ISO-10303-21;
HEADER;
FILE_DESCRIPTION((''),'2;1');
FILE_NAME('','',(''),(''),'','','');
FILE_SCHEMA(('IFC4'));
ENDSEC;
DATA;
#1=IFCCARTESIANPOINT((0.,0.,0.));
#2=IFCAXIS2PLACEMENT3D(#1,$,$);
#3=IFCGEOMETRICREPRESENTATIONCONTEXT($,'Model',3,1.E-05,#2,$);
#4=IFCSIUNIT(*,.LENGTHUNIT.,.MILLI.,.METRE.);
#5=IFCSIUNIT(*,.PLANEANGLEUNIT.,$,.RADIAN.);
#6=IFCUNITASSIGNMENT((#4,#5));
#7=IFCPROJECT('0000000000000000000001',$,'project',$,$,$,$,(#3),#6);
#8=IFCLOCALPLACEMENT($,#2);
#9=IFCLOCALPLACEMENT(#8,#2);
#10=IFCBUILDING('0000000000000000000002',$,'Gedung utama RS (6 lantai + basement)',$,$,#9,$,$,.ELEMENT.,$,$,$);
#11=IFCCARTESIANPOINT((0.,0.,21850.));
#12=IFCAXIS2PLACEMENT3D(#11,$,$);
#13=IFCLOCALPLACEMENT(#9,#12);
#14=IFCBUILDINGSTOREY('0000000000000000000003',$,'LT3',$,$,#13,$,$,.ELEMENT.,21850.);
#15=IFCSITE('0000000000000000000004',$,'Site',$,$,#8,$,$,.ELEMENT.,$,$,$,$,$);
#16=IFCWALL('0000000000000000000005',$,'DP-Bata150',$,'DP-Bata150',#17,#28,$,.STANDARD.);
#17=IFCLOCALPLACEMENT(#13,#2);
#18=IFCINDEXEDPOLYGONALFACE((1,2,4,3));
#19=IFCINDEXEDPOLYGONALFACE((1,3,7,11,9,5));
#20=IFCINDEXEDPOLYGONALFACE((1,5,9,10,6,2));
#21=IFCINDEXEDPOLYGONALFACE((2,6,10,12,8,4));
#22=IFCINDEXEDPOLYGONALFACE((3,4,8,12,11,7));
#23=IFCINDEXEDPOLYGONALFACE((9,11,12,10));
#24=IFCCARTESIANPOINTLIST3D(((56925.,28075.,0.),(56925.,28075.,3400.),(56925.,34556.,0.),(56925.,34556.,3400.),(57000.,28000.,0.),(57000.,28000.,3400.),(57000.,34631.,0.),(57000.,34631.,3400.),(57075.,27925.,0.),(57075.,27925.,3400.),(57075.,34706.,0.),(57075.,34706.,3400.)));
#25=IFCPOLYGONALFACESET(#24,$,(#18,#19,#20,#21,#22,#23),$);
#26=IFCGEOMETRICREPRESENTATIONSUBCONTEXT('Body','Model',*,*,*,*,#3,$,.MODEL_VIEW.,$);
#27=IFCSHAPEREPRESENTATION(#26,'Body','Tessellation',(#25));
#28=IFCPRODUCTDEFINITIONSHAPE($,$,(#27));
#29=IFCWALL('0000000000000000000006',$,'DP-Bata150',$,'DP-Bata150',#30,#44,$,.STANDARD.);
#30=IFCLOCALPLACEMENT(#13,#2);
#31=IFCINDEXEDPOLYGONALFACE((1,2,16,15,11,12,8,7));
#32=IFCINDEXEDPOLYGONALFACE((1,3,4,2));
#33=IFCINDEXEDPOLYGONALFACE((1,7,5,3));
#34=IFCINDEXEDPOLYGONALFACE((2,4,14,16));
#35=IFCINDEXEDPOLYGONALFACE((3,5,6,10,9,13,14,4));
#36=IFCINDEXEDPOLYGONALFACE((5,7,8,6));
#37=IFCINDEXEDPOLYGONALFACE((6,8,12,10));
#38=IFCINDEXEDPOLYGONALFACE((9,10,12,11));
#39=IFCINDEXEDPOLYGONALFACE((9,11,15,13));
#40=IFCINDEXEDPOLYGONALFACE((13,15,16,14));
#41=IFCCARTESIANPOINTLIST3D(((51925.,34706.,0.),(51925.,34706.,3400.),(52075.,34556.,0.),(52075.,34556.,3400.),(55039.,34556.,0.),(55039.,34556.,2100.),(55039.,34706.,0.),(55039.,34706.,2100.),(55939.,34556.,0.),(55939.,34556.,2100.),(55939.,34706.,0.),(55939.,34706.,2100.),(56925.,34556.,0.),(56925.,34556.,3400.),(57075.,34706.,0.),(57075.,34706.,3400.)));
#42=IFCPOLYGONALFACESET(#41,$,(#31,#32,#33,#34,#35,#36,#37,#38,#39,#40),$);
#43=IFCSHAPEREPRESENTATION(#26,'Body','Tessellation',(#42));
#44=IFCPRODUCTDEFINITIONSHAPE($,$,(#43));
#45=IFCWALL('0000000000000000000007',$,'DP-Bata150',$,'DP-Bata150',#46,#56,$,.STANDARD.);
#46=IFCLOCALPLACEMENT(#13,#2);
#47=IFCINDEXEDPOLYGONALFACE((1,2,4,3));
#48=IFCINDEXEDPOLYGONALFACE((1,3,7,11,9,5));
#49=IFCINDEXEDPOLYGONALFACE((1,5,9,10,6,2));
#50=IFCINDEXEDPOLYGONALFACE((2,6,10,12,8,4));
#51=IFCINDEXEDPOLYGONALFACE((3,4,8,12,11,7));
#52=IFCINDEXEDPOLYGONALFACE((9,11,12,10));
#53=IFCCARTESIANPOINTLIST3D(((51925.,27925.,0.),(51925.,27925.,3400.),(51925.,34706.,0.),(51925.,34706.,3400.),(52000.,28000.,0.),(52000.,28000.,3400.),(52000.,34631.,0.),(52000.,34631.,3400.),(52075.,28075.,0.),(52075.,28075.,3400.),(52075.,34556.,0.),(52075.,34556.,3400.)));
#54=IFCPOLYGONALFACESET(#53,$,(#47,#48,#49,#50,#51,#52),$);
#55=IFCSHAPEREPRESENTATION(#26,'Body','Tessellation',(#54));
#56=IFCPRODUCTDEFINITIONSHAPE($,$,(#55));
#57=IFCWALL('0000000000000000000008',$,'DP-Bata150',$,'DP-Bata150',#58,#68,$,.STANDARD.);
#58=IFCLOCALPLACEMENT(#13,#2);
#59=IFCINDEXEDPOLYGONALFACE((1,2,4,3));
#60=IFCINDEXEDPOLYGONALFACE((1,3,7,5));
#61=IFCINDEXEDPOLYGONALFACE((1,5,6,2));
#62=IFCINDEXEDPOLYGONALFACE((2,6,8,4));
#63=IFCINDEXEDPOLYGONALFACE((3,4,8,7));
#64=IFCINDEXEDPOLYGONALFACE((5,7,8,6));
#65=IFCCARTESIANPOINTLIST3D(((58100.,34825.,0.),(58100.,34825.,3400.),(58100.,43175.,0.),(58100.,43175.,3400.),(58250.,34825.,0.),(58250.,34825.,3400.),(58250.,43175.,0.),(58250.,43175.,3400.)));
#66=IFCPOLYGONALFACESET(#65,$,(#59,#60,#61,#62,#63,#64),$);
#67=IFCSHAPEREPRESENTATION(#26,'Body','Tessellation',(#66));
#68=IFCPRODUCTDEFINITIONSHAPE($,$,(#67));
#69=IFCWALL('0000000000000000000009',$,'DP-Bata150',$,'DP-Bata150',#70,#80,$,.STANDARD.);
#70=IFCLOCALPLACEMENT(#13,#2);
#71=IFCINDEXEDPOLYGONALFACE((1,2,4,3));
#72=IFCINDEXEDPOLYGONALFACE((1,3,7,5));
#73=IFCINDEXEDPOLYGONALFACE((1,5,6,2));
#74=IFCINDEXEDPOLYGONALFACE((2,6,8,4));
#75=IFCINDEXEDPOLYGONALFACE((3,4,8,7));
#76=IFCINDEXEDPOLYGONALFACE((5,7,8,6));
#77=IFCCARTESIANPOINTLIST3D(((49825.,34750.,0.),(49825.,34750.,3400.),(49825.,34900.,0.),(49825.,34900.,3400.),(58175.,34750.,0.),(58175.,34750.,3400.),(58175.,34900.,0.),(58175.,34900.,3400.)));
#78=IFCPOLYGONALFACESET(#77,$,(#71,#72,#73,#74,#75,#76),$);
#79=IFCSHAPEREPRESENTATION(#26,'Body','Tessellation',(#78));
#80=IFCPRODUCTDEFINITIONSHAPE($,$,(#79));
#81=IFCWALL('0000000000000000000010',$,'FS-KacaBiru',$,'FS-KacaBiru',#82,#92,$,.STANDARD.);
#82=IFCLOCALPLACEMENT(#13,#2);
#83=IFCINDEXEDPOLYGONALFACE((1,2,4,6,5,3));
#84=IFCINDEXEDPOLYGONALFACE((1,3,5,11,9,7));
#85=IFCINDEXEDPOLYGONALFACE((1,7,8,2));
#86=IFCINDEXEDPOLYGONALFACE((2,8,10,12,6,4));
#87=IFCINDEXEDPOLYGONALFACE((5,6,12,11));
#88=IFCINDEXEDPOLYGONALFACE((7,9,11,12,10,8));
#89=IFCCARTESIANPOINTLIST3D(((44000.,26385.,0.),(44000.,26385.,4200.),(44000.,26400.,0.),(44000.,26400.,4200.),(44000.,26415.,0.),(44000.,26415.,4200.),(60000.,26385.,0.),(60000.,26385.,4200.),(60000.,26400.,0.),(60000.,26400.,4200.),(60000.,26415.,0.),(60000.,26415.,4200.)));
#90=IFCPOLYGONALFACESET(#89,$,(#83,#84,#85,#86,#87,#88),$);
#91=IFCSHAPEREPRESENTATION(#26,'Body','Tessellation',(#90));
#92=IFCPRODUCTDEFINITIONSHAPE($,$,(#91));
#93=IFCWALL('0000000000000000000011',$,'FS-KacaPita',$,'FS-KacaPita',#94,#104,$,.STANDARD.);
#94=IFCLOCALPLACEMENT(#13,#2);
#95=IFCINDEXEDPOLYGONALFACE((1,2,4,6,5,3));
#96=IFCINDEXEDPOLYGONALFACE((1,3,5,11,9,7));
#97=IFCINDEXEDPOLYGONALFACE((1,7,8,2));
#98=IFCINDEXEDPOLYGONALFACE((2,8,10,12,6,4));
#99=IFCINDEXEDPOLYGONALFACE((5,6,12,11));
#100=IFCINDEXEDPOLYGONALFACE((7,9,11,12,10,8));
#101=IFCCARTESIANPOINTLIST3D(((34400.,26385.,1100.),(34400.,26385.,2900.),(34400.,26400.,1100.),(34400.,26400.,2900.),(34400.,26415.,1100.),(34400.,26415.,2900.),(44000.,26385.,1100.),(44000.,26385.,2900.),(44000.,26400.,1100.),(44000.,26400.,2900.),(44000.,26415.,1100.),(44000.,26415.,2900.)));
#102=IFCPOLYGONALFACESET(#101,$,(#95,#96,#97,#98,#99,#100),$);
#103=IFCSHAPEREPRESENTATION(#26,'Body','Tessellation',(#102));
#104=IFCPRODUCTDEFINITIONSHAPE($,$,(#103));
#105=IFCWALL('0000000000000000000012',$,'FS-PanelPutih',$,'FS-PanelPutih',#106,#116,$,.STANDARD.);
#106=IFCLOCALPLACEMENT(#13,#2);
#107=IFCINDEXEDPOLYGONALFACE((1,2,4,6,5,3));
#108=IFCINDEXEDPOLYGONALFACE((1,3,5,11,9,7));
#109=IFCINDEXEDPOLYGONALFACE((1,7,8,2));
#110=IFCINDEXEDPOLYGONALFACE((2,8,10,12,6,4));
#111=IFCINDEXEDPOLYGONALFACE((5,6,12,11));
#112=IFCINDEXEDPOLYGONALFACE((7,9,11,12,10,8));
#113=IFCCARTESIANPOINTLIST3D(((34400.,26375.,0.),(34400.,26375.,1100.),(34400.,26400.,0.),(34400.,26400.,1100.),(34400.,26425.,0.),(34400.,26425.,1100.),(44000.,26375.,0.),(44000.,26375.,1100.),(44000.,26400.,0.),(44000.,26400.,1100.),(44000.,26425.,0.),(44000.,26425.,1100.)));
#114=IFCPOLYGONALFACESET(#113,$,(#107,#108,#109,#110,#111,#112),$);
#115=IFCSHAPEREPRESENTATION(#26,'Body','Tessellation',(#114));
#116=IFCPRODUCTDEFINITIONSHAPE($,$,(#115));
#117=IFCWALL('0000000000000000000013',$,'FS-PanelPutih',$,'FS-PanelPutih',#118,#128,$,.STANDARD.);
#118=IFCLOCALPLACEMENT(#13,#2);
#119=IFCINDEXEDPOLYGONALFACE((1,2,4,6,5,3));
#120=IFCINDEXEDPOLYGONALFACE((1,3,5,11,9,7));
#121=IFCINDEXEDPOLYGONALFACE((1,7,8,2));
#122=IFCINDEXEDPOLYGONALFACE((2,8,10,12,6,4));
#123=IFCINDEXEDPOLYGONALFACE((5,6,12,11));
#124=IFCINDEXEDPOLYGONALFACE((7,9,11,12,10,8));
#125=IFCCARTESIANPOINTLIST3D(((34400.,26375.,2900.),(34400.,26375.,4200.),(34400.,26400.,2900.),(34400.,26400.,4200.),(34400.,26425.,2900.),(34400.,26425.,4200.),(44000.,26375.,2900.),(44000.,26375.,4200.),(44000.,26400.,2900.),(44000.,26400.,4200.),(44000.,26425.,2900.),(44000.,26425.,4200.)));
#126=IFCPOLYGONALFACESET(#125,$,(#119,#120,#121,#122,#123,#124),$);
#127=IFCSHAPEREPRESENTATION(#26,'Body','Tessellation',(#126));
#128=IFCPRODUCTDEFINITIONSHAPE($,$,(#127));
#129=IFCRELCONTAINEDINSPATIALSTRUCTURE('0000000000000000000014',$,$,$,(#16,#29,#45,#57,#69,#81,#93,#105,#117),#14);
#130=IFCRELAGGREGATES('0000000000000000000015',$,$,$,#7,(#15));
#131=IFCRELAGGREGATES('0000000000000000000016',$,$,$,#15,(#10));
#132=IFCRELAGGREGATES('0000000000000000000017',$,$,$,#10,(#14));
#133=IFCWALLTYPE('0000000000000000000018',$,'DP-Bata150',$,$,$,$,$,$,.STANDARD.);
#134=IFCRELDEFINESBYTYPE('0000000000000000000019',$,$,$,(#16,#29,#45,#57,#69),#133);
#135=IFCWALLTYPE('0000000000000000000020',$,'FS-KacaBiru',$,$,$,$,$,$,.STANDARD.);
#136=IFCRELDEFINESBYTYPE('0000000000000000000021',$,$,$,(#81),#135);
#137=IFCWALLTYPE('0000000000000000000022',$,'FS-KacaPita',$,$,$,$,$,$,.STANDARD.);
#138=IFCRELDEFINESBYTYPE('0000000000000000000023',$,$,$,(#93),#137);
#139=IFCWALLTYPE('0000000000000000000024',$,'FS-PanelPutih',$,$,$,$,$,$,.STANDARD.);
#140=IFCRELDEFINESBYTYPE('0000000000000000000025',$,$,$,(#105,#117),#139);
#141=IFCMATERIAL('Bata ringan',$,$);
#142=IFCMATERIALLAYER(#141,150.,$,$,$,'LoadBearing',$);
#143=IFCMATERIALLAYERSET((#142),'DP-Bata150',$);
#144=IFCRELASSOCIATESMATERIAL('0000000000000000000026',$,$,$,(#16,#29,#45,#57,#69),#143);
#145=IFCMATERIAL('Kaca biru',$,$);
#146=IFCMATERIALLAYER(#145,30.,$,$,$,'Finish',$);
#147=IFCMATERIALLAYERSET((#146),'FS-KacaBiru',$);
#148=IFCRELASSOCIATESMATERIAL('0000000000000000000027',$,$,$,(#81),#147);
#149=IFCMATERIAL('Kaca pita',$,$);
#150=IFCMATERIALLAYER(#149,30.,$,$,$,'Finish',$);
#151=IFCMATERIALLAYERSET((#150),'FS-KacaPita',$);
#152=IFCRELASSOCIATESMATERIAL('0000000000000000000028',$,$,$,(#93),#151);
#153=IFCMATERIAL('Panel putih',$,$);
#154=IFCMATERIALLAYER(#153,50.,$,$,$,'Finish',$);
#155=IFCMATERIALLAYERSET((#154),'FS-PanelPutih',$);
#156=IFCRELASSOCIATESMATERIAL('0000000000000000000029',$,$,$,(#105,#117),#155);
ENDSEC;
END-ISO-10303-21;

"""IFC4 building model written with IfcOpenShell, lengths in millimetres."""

from ifc_helpers import new_model, si_unit, frame, frame_2d, origin, place, context, subcontext, project, spatial, polyline, rectangle, outline, extrude, material, layer, layer_set, layer_usage, type_object, element, save


model = new_model("IFC4")

# Units and contexts
model_context = context("Model", 3, precision=1e-05, world=origin())
body_context = subcontext(model_context, "Body", "Model", "MODEL_VIEW")
ifc_project = project(units=[si_unit("LENGTHUNIT", "METRE", prefix="MILLI"), si_unit("PLANEANGLEUNIT", "RADIAN")], contexts=[model_context])

# Site, building, storey
site_placement = place(None, origin())
site = spatial("IfcSite", under=ifc_project, at=site_placement, Name="Site", CompositionType="ELEMENT")
building_placement = place(site_placement, origin())
building = spatial("IfcBuilding", under=site, at=building_placement, Name="Gedung utama RS (6 lantai + basement)", CompositionType="ELEMENT")
storey_placement = place(building_placement, frame((0.0, 0.0, 21850.0)))
storey = spatial("IfcBuildingStorey", under=building, at=storey_placement, Name="LT3", CompositionType="ELEMENT", Elevation=21850.0)

# Shared definitions
ifc_material_1 = material(Name="Bata ringan")
ifc_layer_1 = layer(ifc_material_1, 150.0, Category="LoadBearing")
ifc_layer_set_1 = layer_set([ifc_layer_1], Name="DP-Bata150")
ifc_layer_usage_1 = layer_usage(ifc_layer_set_1, "AXIS2", "NEGATIVE", 75.0)
wall_type_1 = type_object("IfcWallType", Name="DP-Bata150", PredefinedType="STANDARD")

# Wall
wall_1_placement = place(storey_placement, frame((57000.0, 28000.0, 0.0), z_axis=(0.0, 0.0, 1.0), x_axis=(0.0, 1.0, 0.0)))
element("IfcWall", 1, at=wall_1_placement, inside=storey, type_object=wall_type_1, material=ifc_layer_usage_1, Name="DP-Bata150", ObjectType="DP-Bata150", PredefinedType="STANDARD", context=body_context, shape_type="SweptSolid", body=[
    extrude(outline(polyline([(-75.0, -75.0), (0.0, 0.0), (75.0, 75.0), (6556.0, 75.0), (6631.0, 0.0), (6706.0, -75.0), (-75.0, -75.0)])), origin(), (0.0, 0.0, 1.0), 3400.0),
])

# Wall, opening
wall_2_placement = place(storey_placement, frame((57000.0, 34631.0, 0.0), z_axis=(0.0, 0.0, 1.0), x_axis=(-1.0, 0.0, 0.0)))
wall_2 = element("IfcWall", 2, at=wall_2_placement, inside=storey, type_object=wall_type_1, material=ifc_layer_usage_1, Name="DP-Bata150", ObjectType="DP-Bata150", PredefinedType="STANDARD", context=body_context, shape_type="SweptSolid", body=[
    extrude(outline(polyline([(-75.0, -75.0), (0.0, 0.0), (75.0, 75.0), (4925.0, 75.0), (5000.0, 0.0), (5075.0, -75.0), (-75.0, -75.0)])), origin(), (0.0, 0.0, 1.0), 3400.0),
])
opening_1_placement = place(wall_2_placement, frame((1061.0, 0.0, 0.0), z_axis=(0.0, 0.0, 1.0), x_axis=(1.0, 0.0, 0.0)))
element("IfcOpeningElement", 3, at=opening_1_placement, cuts=wall_2, PredefinedType="OPENING", context=body_context, shape_type="SweptSolid", body=[
    extrude(rectangle(XDim=900.0, YDim=170.0, at=frame_2d((450.0, 0.0))), origin(), (0.0, 0.0, 1.0), 2100.0),
])

# Walls
wall_3_placement = place(storey_placement, frame((52000.0, 34631.0, 0.0), z_axis=(0.0, 0.0, 1.0), x_axis=(0.0, -1.0, 0.0)))
element("IfcWall", 4, at=wall_3_placement, inside=storey, type_object=wall_type_1, material=ifc_layer_usage_1, Name="DP-Bata150", ObjectType="DP-Bata150", PredefinedType="STANDARD", context=body_context, shape_type="SweptSolid", body=[
    extrude(outline(polyline([(-75.0, -75.0), (0.0, 0.0), (75.0, 75.0), (6556.0, 75.0), (6631.0, 0.0), (6706.0, -75.0), (-75.0, -75.0)])), origin(), (0.0, 0.0, 1.0), 3400.0),
])
for number, where, z_axis, x_axis, name in (
    (5, (58175.0, 34825.0, 0.0), (0.0, 0.0, 1.0), (0.0, 1.0, 0.0), "DP-Bata150"),
    (6, (49825.0, 34825.0, 0.0), (0.0, 0.0, 1.0), (1.0, 0.0, 0.0), "DP-Bata150"),
):
    element("IfcWall", number, at=place(storey_placement, frame(where, z_axis=z_axis, x_axis=x_axis)), inside=storey, type_object=wall_type_1, material=ifc_layer_usage_1, Name=name, ObjectType="DP-Bata150", PredefinedType="STANDARD", context=body_context, shape_type="SweptSolid", body=[
        extrude(outline(polyline([(0.0, -75.0), (0.0, 75.0), (8350.0, 75.0), (8350.0, -75.0), (0.0, -75.0)])), origin(), (0.0, 0.0, 1.0), 3400.0),
    ])
ifc_material_2 = material(Name="Kaca biru")
ifc_layer_2 = layer(ifc_material_2, 30.0, Category="Finish")
ifc_layer_set_2 = layer_set([ifc_layer_2], Name="FS-KacaBiru")
ifc_layer_usage_2 = layer_usage(ifc_layer_set_2, "AXIS2", "NEGATIVE", 15.0)
wall_type_2 = type_object("IfcWallType", Name="FS-KacaBiru", PredefinedType="STANDARD")
wall_4_placement = place(storey_placement, frame((60000.0, 26400.0, 0.0), z_axis=(0.0, 0.0, 1.0), x_axis=(-1.0, 0.0, 0.0)))
element("IfcWall", 7, at=wall_4_placement, inside=storey, type_object=wall_type_2, material=ifc_layer_usage_2, Name="FS-KacaBiru", ObjectType="FS-KacaBiru", PredefinedType="STANDARD", context=body_context, shape_type="SweptSolid", body=[
    extrude(outline(polyline([(0.0, -15.0), (0.0, 0.0), (0.0, 15.0), (16000.0, 15.0), (16000.0, 0.0), (16000.0, -15.0), (0.0, -15.0)])), origin(), (0.0, 0.0, 1.0), 4200.0),
])
ifc_material_3 = material(Name="Kaca pita")
ifc_layer_3 = layer(ifc_material_3, 30.0, Category="Finish")
ifc_layer_set_3 = layer_set([ifc_layer_3], Name="FS-KacaPita")
ifc_layer_usage_3 = layer_usage(ifc_layer_set_3, "AXIS2", "NEGATIVE", 15.0)
wall_type_3 = type_object("IfcWallType", Name="FS-KacaPita", PredefinedType="STANDARD")
wall_5_placement = place(storey_placement, frame((44000.0, 26400.0, 1100.0), z_axis=(0.0, 0.0, 1.0), x_axis=(-1.0, 0.0, 0.0)))
element("IfcWall", 8, at=wall_5_placement, inside=storey, type_object=wall_type_3, material=ifc_layer_usage_3, Name="FS-KacaPita", ObjectType="FS-KacaPita", PredefinedType="STANDARD", context=body_context, shape_type="SweptSolid", body=[
    extrude(outline(polyline([(0.0, -15.0), (0.0, 0.0), (0.0, 15.0), (9600.0, 15.0), (9600.0, 0.0), (9600.0, -15.0), (0.0, -15.0)])), origin(), (0.0, 0.0, 1.0), 1800.0),
])
ifc_material_4 = material(Name="Panel putih")
ifc_layer_4 = layer(ifc_material_4, 50.0, Category="Finish")
ifc_layer_set_4 = layer_set([ifc_layer_4], Name="FS-PanelPutih")
ifc_layer_usage_4 = layer_usage(ifc_layer_set_4, "AXIS2", "NEGATIVE", 25.0)
wall_type_4 = type_object("IfcWallType", Name="FS-PanelPutih", PredefinedType="STANDARD")
wall_6_placement = place(storey_placement, frame((44000.0, 26400.0, 0.0), z_axis=(0.0, 0.0, 1.0), x_axis=(-1.0, 0.0, 0.0)))
element("IfcWall", 9, at=wall_6_placement, inside=storey, type_object=wall_type_4, material=ifc_layer_usage_4, Name="FS-PanelPutih", ObjectType="FS-PanelPutih", PredefinedType="STANDARD", context=body_context, shape_type="SweptSolid", body=[
    extrude(outline(polyline([(0.0, -25.0), (0.0, 0.0), (0.0, 25.0), (9600.0, 25.0), (9600.0, 0.0), (9600.0, -25.0), (0.0, -25.0)])), origin(), (0.0, 0.0, 1.0), 1100.0),
])
wall_7_placement = place(storey_placement, frame((44000.0, 26400.0, 2900.0), z_axis=(0.0, 0.0, 1.0), x_axis=(-1.0, 0.0, 0.0)))
element("IfcWall", 10, at=wall_7_placement, inside=storey, type_object=wall_type_4, material=ifc_layer_usage_4, Name="FS-PanelPutih", ObjectType="FS-PanelPutih", PredefinedType="STANDARD", context=body_context, shape_type="SweptSolid", body=[
    extrude(outline(polyline([(0.0, -25.0), (0.0, 0.0), (0.0, 25.0), (9600.0, 25.0), (9600.0, 0.0), (9600.0, -25.0), (0.0, -25.0)])), origin(), (0.0, 0.0, 1.0), 1300.0),
])

save(model, "model.ifc")
